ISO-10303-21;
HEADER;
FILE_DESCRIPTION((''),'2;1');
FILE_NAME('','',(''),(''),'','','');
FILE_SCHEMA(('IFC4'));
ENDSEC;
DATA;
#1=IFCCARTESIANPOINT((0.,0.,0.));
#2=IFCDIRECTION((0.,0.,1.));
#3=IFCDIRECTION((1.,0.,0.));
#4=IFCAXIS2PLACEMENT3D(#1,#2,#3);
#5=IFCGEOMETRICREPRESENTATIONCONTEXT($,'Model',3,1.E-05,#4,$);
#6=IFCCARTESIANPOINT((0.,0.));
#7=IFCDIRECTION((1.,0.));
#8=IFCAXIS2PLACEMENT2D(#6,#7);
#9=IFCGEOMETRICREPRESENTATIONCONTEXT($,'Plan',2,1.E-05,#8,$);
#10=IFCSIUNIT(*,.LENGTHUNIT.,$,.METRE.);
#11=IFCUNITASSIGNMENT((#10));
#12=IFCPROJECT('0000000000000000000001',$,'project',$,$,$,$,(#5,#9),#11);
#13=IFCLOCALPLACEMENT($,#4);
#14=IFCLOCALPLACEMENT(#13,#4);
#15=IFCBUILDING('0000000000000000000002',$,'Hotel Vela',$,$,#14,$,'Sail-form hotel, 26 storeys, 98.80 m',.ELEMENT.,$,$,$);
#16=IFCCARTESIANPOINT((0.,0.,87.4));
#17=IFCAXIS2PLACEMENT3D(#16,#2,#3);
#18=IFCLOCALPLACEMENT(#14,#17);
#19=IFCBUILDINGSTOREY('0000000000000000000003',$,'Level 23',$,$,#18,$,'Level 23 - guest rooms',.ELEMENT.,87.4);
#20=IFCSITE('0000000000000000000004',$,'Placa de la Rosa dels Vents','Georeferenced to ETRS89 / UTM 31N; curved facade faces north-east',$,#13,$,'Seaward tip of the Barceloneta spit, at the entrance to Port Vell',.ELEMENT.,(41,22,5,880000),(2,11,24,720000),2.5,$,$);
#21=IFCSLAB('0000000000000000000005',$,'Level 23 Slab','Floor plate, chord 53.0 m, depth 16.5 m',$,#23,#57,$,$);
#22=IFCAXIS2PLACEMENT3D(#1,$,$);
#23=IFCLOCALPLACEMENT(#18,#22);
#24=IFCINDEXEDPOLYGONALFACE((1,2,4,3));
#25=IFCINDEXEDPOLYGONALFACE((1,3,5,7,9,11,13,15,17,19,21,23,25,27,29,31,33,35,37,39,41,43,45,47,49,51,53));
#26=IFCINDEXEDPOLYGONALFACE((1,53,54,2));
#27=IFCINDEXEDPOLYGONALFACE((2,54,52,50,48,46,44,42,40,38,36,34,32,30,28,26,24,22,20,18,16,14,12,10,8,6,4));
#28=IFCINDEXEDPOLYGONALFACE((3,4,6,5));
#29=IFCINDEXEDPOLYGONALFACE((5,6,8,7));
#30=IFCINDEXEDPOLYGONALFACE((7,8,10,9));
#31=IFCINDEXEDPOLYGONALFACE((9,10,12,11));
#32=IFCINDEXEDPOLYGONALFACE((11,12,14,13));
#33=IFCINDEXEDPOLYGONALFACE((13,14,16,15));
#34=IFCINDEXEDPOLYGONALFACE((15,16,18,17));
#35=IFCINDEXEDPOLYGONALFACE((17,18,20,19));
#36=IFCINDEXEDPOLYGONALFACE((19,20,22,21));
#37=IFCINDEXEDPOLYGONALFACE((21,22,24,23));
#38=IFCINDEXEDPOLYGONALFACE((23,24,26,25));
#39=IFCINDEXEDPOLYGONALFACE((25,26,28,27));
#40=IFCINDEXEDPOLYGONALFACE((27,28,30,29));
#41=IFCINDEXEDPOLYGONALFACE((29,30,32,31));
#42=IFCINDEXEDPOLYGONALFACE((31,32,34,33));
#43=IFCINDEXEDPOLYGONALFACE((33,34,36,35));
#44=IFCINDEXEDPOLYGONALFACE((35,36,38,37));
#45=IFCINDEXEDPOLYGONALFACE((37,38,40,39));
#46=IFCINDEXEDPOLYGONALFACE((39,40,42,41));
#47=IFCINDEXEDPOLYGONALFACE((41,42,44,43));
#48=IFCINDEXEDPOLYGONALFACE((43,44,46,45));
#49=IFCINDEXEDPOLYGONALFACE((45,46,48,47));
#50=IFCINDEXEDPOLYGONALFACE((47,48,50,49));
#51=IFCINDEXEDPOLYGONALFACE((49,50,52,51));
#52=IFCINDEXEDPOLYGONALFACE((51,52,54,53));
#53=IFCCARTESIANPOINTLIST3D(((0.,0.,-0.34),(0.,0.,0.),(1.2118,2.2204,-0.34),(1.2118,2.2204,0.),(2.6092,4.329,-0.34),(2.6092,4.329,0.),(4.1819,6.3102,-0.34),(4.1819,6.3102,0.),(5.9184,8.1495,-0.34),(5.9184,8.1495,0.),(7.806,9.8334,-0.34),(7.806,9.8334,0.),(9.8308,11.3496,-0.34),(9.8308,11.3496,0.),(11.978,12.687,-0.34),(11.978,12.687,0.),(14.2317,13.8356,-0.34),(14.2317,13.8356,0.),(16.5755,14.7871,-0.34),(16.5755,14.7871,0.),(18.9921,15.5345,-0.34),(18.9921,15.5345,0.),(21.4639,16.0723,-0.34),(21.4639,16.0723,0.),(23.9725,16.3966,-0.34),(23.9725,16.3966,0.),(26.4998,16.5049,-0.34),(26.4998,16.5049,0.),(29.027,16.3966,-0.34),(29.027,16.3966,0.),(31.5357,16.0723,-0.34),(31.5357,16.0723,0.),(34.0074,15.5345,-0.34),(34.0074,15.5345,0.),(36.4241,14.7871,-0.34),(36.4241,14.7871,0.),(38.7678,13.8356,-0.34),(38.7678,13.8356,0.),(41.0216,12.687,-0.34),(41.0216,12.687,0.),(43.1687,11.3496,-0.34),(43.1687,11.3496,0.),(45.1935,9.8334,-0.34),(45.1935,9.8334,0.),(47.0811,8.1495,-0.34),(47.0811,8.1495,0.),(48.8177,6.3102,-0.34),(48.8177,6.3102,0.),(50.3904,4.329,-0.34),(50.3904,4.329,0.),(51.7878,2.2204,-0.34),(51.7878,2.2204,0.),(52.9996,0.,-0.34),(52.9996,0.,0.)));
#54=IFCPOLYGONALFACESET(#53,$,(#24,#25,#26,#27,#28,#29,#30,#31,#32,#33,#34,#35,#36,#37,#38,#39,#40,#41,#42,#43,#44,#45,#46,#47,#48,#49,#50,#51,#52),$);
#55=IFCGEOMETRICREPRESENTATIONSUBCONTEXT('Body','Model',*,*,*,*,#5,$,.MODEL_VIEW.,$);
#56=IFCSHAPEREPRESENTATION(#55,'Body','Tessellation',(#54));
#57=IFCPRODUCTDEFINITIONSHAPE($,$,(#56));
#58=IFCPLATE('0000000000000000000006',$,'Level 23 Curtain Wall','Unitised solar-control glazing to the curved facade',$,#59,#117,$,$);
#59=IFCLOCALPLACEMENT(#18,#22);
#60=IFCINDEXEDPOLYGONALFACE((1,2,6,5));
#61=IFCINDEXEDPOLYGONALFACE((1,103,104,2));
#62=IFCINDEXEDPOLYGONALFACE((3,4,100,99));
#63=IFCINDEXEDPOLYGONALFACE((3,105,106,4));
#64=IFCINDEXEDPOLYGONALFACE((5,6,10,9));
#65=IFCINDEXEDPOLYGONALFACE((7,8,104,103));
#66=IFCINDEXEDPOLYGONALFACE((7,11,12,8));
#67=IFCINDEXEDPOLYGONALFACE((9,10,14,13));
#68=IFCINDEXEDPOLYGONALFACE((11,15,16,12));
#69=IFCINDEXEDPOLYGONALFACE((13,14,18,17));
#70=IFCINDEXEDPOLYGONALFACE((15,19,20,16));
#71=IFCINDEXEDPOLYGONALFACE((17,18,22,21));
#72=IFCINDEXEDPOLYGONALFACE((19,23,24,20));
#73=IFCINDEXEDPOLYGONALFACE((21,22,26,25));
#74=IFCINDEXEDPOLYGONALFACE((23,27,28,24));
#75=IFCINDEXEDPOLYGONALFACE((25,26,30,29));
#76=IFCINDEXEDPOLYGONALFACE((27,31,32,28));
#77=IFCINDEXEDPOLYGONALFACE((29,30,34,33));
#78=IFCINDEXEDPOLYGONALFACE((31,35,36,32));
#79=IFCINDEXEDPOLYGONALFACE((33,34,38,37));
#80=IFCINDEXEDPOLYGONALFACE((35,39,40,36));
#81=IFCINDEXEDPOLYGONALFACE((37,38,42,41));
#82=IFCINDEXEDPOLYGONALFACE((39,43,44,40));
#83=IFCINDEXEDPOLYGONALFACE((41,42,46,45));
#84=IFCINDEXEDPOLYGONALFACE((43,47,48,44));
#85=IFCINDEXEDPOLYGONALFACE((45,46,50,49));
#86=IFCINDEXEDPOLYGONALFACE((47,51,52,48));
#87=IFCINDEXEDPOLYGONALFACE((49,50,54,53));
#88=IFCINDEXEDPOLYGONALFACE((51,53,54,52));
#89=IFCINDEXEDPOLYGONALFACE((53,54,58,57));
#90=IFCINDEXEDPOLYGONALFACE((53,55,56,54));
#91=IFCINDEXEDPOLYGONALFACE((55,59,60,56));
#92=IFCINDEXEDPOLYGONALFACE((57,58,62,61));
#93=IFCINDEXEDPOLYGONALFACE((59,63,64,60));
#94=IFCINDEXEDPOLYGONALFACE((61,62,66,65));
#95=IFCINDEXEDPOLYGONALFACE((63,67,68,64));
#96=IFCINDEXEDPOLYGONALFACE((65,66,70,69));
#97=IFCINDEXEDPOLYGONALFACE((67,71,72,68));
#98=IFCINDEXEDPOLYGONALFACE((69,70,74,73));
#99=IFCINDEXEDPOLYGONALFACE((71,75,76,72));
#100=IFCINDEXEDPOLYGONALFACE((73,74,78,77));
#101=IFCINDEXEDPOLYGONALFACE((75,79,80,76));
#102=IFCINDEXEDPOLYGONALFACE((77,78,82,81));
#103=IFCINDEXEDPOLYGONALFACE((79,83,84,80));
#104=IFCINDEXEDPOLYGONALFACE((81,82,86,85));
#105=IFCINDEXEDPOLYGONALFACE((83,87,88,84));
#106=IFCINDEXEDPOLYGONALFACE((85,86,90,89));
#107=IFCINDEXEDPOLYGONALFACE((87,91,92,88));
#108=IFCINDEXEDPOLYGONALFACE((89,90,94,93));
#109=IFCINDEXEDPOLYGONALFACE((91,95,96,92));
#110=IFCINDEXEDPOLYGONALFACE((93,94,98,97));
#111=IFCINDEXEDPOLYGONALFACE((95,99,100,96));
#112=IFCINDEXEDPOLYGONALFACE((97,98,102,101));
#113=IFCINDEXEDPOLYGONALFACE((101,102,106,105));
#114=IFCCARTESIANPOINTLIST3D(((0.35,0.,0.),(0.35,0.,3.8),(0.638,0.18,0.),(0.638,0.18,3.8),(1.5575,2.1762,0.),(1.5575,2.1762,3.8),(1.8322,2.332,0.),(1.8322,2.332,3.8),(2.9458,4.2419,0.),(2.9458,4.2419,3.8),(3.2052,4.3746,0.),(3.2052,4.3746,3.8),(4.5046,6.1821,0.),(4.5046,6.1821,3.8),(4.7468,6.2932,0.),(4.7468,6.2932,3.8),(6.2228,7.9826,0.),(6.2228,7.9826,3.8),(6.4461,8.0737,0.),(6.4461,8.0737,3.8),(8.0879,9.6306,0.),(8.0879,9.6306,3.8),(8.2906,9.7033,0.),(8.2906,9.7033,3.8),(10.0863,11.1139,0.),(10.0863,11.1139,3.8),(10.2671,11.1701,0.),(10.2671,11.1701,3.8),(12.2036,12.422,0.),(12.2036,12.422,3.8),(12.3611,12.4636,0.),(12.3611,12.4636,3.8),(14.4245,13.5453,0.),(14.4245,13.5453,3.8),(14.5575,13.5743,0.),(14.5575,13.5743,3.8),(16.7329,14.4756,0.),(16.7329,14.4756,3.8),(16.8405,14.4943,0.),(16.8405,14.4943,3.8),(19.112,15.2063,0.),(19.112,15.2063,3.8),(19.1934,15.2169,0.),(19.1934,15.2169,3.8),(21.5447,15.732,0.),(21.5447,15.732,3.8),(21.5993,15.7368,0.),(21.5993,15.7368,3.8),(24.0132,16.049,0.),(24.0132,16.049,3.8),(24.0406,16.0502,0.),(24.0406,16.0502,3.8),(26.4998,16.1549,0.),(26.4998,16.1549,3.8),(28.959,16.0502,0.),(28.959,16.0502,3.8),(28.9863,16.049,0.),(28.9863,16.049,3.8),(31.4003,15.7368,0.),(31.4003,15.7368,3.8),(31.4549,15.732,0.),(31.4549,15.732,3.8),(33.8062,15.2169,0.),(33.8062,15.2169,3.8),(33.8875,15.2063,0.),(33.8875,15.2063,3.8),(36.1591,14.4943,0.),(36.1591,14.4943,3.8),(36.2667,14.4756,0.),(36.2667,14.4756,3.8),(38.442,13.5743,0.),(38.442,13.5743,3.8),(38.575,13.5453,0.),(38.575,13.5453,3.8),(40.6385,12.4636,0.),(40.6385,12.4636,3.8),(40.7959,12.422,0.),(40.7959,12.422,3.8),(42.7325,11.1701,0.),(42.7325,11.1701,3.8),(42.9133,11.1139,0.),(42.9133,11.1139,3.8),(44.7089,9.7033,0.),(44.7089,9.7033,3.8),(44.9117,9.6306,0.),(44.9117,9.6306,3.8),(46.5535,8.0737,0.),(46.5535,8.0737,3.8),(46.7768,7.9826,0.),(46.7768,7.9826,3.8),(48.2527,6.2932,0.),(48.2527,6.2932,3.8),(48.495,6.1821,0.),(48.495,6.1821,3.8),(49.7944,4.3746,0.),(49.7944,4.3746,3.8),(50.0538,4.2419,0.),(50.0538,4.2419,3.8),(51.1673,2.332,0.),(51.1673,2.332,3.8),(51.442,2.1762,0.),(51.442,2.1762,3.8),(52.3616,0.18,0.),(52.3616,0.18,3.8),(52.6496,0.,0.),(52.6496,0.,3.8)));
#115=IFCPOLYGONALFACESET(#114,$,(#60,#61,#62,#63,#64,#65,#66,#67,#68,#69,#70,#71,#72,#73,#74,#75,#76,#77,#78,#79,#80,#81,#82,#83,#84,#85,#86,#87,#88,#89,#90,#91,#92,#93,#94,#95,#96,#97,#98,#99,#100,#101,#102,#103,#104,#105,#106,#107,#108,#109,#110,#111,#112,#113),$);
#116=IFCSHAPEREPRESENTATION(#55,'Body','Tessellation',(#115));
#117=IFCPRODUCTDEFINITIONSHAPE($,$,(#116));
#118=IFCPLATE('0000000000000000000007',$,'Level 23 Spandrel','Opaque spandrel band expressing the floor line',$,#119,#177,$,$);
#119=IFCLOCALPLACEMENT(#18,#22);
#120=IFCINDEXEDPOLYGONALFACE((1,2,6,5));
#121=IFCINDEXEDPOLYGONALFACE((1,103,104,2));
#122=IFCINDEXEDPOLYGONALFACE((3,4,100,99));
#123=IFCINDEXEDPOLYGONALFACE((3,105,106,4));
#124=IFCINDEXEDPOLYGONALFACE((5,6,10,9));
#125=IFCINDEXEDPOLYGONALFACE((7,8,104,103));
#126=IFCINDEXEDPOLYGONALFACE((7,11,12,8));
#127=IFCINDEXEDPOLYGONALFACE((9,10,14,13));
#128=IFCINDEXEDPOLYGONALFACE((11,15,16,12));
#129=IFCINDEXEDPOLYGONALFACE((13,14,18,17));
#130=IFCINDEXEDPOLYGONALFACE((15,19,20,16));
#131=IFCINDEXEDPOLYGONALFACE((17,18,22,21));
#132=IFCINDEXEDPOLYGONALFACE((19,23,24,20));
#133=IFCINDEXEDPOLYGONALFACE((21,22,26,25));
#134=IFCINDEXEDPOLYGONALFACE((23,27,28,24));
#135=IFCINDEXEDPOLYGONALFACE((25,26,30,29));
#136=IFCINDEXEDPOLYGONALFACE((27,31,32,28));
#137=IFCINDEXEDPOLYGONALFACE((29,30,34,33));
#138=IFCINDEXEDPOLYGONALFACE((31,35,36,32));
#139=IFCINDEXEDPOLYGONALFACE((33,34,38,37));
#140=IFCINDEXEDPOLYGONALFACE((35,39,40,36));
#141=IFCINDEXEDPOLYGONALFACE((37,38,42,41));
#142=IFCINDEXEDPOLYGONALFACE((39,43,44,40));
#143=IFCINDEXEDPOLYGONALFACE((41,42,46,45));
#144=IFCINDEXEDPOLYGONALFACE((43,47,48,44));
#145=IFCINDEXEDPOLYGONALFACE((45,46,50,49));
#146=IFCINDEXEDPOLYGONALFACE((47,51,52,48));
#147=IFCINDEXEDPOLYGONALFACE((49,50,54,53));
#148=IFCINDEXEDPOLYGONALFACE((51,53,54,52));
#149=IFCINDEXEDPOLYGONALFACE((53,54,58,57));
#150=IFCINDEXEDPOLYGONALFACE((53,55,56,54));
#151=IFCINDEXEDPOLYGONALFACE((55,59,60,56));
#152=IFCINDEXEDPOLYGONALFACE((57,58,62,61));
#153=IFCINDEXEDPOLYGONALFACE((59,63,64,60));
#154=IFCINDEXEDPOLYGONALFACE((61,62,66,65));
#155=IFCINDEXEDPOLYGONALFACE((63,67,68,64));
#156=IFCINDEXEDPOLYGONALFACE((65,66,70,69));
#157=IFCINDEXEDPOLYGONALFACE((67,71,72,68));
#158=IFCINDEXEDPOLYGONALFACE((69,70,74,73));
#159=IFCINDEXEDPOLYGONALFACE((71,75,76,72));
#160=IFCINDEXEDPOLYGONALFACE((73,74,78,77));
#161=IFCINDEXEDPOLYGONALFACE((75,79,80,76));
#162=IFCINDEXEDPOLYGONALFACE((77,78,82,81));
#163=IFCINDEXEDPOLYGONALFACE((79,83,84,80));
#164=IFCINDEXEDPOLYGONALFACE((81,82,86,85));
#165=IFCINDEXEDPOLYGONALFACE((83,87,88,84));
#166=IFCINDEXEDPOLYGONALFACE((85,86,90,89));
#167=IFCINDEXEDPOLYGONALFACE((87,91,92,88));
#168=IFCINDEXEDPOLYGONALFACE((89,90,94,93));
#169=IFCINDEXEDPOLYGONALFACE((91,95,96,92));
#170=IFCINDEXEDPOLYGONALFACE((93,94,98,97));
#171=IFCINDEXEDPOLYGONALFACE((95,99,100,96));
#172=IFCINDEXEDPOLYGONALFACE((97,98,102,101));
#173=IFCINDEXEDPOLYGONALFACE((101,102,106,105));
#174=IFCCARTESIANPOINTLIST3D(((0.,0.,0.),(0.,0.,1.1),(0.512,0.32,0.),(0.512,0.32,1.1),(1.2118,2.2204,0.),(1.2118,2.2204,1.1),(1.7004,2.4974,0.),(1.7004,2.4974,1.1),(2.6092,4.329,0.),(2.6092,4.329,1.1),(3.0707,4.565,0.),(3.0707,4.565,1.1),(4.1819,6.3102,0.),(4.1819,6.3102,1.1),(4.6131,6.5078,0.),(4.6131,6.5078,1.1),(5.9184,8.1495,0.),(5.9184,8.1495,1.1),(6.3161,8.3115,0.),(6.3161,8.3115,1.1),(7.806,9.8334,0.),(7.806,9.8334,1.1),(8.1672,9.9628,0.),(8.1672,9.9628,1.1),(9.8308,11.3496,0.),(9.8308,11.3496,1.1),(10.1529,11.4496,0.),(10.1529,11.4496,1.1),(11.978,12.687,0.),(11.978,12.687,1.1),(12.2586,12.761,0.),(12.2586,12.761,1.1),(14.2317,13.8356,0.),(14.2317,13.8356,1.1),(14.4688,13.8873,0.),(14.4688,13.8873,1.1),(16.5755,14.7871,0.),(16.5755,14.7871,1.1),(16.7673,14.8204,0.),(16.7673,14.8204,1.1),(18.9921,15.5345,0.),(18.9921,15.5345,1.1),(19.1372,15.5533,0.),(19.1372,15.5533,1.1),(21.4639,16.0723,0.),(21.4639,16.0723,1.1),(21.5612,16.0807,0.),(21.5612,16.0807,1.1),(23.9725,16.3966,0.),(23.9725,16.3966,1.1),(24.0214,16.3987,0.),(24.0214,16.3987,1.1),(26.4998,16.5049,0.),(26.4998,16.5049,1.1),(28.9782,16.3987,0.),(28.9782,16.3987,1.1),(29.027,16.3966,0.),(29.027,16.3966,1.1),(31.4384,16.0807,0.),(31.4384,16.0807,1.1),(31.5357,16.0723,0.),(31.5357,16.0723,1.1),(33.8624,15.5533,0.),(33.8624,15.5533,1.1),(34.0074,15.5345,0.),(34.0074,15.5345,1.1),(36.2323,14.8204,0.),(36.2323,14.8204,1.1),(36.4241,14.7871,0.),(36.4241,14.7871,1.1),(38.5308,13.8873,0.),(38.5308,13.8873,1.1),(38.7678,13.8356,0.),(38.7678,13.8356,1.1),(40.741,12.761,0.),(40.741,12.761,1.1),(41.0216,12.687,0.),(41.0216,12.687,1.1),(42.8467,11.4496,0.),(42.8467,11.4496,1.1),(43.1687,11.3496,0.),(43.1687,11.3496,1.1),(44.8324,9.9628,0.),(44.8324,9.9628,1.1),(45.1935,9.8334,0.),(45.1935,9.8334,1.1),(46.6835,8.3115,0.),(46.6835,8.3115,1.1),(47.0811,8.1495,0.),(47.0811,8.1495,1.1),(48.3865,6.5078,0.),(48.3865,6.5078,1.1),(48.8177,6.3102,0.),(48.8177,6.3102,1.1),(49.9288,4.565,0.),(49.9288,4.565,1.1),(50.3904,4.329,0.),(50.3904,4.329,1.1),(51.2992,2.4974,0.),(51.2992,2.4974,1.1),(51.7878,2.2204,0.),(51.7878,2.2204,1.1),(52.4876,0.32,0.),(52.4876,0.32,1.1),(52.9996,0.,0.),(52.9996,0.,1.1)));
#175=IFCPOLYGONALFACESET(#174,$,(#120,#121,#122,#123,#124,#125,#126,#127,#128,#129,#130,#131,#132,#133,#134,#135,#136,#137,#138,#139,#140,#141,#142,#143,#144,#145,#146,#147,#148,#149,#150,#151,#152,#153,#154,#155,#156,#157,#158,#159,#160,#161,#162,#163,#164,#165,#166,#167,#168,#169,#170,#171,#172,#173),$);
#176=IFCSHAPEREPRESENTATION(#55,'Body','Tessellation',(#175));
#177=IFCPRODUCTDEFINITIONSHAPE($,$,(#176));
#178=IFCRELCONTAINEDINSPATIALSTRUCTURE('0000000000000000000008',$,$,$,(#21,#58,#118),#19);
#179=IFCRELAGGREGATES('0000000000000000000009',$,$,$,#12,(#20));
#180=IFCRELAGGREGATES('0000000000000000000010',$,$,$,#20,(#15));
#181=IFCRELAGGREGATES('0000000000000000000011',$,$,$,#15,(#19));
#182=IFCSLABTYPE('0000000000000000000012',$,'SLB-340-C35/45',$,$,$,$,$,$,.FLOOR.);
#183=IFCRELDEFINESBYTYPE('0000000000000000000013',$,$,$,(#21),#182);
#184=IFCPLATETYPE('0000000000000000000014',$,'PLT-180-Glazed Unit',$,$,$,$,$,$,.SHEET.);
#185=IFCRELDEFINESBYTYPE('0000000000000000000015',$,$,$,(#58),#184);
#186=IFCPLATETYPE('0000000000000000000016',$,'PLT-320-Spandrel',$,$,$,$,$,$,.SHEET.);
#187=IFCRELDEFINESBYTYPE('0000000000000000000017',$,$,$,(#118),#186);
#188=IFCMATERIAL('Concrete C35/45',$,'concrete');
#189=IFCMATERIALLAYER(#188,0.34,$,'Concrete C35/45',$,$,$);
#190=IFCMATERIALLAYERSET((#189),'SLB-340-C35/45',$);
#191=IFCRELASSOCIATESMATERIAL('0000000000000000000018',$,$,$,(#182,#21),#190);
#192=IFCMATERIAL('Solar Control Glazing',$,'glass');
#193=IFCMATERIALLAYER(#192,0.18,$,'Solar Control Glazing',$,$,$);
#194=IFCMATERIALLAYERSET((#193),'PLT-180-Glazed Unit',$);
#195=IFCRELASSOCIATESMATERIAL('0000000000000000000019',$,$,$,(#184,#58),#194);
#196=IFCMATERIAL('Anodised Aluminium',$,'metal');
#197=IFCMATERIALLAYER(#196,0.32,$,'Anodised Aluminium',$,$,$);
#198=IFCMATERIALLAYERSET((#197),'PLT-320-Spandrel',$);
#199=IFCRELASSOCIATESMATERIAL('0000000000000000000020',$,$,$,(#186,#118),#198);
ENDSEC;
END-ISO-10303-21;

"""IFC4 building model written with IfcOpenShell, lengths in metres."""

from ifc_helpers import new_model, si_unit, frame, origin_with_axes, origin_2d_with_axis, place, context, subcontext, project, spatial, line, indexed_curve, outline, extrude, material, layer, layer_set, layer_usage, type_object, element, save


model = new_model("IFC4")

# Units and contexts
model_context = context("Model", 3, precision=1e-05, world=origin_with_axes())
plan_context = context("Plan", 2, precision=1e-05, world=origin_2d_with_axis())
body_context = subcontext(model_context, "Body", "Model", "MODEL_VIEW")
ifc_project = project(units=[si_unit("LENGTHUNIT", "METRE")], contexts=[model_context, plan_context])

# Site, building, storey
site_placement = place(None, origin_with_axes())
site = spatial("IfcSite", under=ifc_project, at=site_placement, Name="Placa de la Rosa dels Vents", Description="Georeferenced to ETRS89 / UTM 31N; curved facade faces north-east", LongName="Seaward tip of the Barceloneta spit, at the entrance to Port Vell", CompositionType="ELEMENT", RefLatitude=(41, 22, 5, 880000), RefLongitude=(2, 11, 24, 720000), RefElevation=2.5)
building_placement = place(site_placement, origin_with_axes())
building = spatial("IfcBuilding", under=site, at=building_placement, Name="Hotel Vela", LongName="Sail-form hotel, 26 storeys, 98.80 m", CompositionType="ELEMENT")
storey_placement = place(building_placement, frame((0.0, 0.0, 87.4), z_axis=(0.0, 0.0, 1.0), x_axis=(1.0, 0.0, 0.0)))
storey = spatial("IfcBuildingStorey", under=building, at=storey_placement, Name="Level 23", LongName="Level 23 - guest rooms", CompositionType="ELEMENT", Elevation=87.4)

# Slab
ifc_material_1 = material(Name="Concrete C35/45", Category="concrete")
ifc_layer_1 = layer(ifc_material_1, 0.34, Name="Concrete C35/45")
ifc_layer_set_1 = layer_set([ifc_layer_1], Name="SLB-340-C35/45")
ifc_layer_usage_1 = layer_usage(ifc_layer_set_1, "AXIS3", "POSITIVE", 0.0)
slab_type = type_object("IfcSlabType", Name="SLB-340-C35/45", PredefinedType="FLOOR", material=ifc_layer_set_1)
slab_placement = place(storey_placement, frame((0.0, 0.0, -0.34), z_axis=(0.0, 0.0, 1.0), x_axis=(1.0, 0.0, 0.0)))
element("IfcSlab", 1, at=slab_placement, inside=storey, type_object=slab_type, material=ifc_layer_usage_1, Name="Level 23 Slab", Description="Floor plate, chord 53.0 m, depth 16.5 m", context=body_context, shape_type="SweptSolid", body=[
    extrude(outline(indexed_curve([(0.0, 0.0), (52.9996, 0.0), (51.7878, 2.2204), (50.3904, 4.329), (48.8177, 6.3102), (47.0811, 8.1495), (45.1935, 9.8334), (43.1687, 11.3496), (41.0216, 12.687), (38.7678, 13.8356), (36.4241, 14.7871), (34.0074, 15.5345), (31.5357, 16.0723), (29.027, 16.3966), (26.4998, 16.5049), (23.9725, 16.3966), (21.4639, 16.0723), (18.9921, 15.5345), (16.5755, 14.7871), (14.2317, 13.8356), (11.978, 12.687), (9.8308, 11.3496), (7.806, 9.8334), (5.9184, 8.1495), (4.1819, 6.3102), (2.6092, 4.329), (1.2118, 2.2204)], segments=[line(1, 2, 3, 4, 5, 6, 7, 8, 9, 10, 11, 12, 13, 14, 15, 16, 17, 18, 19, 20, 21, 22, 23, 24, 25, 26, 27, 1)])), origin_with_axes(), (0.0, 0.0, 1.0), 0.34),
])

# Plates
ifc_material_2 = material(Name="Solar Control Glazing", Category="glass")
ifc_layer_2 = layer(ifc_material_2, 0.18, Name="Solar Control Glazing")
ifc_layer_set_2 = layer_set([ifc_layer_2], Name="PLT-180-Glazed Unit")
ifc_layer_usage_2 = layer_usage(ifc_layer_set_2, "AXIS2", "POSITIVE", 0.0)
plate_type_1 = type_object("IfcPlateType", Name="PLT-180-Glazed Unit", PredefinedType="SHEET", material=ifc_layer_set_2)
plate_1_placement = place(storey_placement, frame((0.35, 0.0, 0.0), z_axis=(0.0, 0.0, 1.0), x_axis=(1.0, 0.0, 0.0)))
element("IfcPlate", 2, at=plate_1_placement, inside=storey, type_object=plate_type_1, material=ifc_layer_usage_2, Name="Level 23 Curtain Wall", Description="Unitised solar-control glazing to the curved facade", context=body_context, shape_type="SweptSolid", body=[
    extrude(outline(indexed_curve([(52.2996, 0.0), (51.092, 2.1762), (49.7038, 4.2419), (48.145, 6.1821), (46.4268, 7.9826), (44.5617, 9.6306), (42.5633, 11.1139), (40.4459, 12.422), (38.225, 13.5453), (35.9167, 14.4756), (33.5375, 15.2063), (31.1049, 15.732), (28.6363, 16.049), (26.1498, 16.1549), (23.6632, 16.049), (21.1947, 15.732), (18.762, 15.2063), (16.3829, 14.4756), (14.0745, 13.5453), (11.8536, 12.422), (9.7363, 11.1139), (7.7379, 9.6306), (5.8728, 7.9826), (4.1546, 6.1821), (2.5958, 4.2419), (1.2075, 2.1762), (0.0, 0.0), (52.0116, 0.18), (1.4822, 2.332), (2.8552, 4.3746), (4.3968, 6.2932), (6.0961, 8.0737), (7.9406, 9.7033), (9.9171, 11.1701), (12.0111, 12.4636), (14.2075, 13.5743), (16.4905, 14.4943), (18.8434, 15.2169), (21.2493, 15.7368), (23.6906, 16.0502), (26.1498, 16.1549), (28.609, 16.0502), (31.0503, 15.7368), (33.4562, 15.2169), (35.8091, 14.4943), (38.092, 13.5743), (40.2885, 12.4636), (42.3825, 11.1701), (44.3589, 9.7033), (46.2035, 8.0737), (47.9027, 6.2932), (49.4444, 4.3746), (50.8173, 2.332), (0.288, 0.18)], segments=[line(1, 2, 3, 4, 5, 6, 7, 8, 9, 10, 11, 12, 13, 14, 15, 16, 17, 18, 19, 20, 21, 22, 23, 24, 25, 26, 27, 28, 29, 30, 31, 32, 33, 34, 35, 36, 37, 38, 39, 40, 41, 42, 43, 44, 45, 46, 47, 48, 49, 50, 51, 52, 53, 54, 1)])), origin_with_axes(), (0.0, 0.0, 1.0), 3.8),
])
ifc_material_3 = material(Name="Anodised Aluminium", Category="metal")
ifc_layer_3 = layer(ifc_material_3, 0.32, Name="Anodised Aluminium")
ifc_layer_set_3 = layer_set([ifc_layer_3], Name="PLT-320-Spandrel")
ifc_layer_usage_3 = layer_usage(ifc_layer_set_3, "AXIS2", "POSITIVE", 0.0)
plate_type_2 = type_object("IfcPlateType", Name="PLT-320-Spandrel", PredefinedType="SHEET", material=ifc_layer_set_3)
plate_2_placement = place(storey_placement, origin_with_axes())
element("IfcPlate", 3, at=plate_2_placement, inside=storey, type_object=plate_type_2, material=ifc_layer_usage_3, Name="Level 23 Spandrel", Description="Opaque spandrel band expressing the floor line", context=body_context, shape_type="SweptSolid", body=[
    extrude(outline(indexed_curve([(52.9996, 0.0), (51.7878, 2.2204), (50.3904, 4.329), (48.8177, 6.3102), (47.0811, 8.1495), (45.1935, 9.8334), (43.1687, 11.3496), (41.0216, 12.687), (38.7678, 13.8356), (36.4241, 14.7871), (34.0074, 15.5345), (31.5357, 16.0723), (29.027, 16.3966), (26.4998, 16.5049), (23.9725, 16.3966), (21.4639, 16.0723), (18.9921, 15.5345), (16.5755, 14.7871), (14.2317, 13.8356), (11.978, 12.687), (9.8308, 11.3496), (7.806, 9.8334), (5.9184, 8.1495), (4.1819, 6.3102), (2.6092, 4.329), (1.2118, 2.2204), (0.0, 0.0), (52.4876, 0.32), (1.7004, 2.4974), (3.0707, 4.565), (4.6131, 6.5078), (6.3161, 8.3115), (8.1672, 9.9628), (10.1529, 11.4496), (12.2586, 12.761), (14.4688, 13.8873), (16.7673, 14.8204), (19.1372, 15.5533), (21.5612, 16.0807), (24.0214, 16.3987), (26.4998, 16.5049), (28.9782, 16.3987), (31.4384, 16.0807), (33.8624, 15.5533), (36.2323, 14.8204), (38.5308, 13.8873), (40.741, 12.761), (42.8467, 11.4496), (44.8324, 9.9628), (46.6835, 8.3115), (48.3865, 6.5078), (49.9288, 4.565), (51.2992, 2.4974), (0.512, 0.32)], segments=[line(1, 2, 3, 4, 5, 6, 7, 8, 9, 10, 11, 12, 13, 14, 15, 16, 17, 18, 19, 20, 21, 22, 23, 24, 25, 26, 27, 28, 29, 30, 31, 32, 33, 34, 35, 36, 37, 38, 39, 40, 41, 42, 43, 44, 45, 46, 47, 48, 49, 50, 51, 52, 53, 54, 1)])), origin_with_axes(), (0.0, 0.0, 1.0), 1.1),
])

save(model, "model.ifc")
